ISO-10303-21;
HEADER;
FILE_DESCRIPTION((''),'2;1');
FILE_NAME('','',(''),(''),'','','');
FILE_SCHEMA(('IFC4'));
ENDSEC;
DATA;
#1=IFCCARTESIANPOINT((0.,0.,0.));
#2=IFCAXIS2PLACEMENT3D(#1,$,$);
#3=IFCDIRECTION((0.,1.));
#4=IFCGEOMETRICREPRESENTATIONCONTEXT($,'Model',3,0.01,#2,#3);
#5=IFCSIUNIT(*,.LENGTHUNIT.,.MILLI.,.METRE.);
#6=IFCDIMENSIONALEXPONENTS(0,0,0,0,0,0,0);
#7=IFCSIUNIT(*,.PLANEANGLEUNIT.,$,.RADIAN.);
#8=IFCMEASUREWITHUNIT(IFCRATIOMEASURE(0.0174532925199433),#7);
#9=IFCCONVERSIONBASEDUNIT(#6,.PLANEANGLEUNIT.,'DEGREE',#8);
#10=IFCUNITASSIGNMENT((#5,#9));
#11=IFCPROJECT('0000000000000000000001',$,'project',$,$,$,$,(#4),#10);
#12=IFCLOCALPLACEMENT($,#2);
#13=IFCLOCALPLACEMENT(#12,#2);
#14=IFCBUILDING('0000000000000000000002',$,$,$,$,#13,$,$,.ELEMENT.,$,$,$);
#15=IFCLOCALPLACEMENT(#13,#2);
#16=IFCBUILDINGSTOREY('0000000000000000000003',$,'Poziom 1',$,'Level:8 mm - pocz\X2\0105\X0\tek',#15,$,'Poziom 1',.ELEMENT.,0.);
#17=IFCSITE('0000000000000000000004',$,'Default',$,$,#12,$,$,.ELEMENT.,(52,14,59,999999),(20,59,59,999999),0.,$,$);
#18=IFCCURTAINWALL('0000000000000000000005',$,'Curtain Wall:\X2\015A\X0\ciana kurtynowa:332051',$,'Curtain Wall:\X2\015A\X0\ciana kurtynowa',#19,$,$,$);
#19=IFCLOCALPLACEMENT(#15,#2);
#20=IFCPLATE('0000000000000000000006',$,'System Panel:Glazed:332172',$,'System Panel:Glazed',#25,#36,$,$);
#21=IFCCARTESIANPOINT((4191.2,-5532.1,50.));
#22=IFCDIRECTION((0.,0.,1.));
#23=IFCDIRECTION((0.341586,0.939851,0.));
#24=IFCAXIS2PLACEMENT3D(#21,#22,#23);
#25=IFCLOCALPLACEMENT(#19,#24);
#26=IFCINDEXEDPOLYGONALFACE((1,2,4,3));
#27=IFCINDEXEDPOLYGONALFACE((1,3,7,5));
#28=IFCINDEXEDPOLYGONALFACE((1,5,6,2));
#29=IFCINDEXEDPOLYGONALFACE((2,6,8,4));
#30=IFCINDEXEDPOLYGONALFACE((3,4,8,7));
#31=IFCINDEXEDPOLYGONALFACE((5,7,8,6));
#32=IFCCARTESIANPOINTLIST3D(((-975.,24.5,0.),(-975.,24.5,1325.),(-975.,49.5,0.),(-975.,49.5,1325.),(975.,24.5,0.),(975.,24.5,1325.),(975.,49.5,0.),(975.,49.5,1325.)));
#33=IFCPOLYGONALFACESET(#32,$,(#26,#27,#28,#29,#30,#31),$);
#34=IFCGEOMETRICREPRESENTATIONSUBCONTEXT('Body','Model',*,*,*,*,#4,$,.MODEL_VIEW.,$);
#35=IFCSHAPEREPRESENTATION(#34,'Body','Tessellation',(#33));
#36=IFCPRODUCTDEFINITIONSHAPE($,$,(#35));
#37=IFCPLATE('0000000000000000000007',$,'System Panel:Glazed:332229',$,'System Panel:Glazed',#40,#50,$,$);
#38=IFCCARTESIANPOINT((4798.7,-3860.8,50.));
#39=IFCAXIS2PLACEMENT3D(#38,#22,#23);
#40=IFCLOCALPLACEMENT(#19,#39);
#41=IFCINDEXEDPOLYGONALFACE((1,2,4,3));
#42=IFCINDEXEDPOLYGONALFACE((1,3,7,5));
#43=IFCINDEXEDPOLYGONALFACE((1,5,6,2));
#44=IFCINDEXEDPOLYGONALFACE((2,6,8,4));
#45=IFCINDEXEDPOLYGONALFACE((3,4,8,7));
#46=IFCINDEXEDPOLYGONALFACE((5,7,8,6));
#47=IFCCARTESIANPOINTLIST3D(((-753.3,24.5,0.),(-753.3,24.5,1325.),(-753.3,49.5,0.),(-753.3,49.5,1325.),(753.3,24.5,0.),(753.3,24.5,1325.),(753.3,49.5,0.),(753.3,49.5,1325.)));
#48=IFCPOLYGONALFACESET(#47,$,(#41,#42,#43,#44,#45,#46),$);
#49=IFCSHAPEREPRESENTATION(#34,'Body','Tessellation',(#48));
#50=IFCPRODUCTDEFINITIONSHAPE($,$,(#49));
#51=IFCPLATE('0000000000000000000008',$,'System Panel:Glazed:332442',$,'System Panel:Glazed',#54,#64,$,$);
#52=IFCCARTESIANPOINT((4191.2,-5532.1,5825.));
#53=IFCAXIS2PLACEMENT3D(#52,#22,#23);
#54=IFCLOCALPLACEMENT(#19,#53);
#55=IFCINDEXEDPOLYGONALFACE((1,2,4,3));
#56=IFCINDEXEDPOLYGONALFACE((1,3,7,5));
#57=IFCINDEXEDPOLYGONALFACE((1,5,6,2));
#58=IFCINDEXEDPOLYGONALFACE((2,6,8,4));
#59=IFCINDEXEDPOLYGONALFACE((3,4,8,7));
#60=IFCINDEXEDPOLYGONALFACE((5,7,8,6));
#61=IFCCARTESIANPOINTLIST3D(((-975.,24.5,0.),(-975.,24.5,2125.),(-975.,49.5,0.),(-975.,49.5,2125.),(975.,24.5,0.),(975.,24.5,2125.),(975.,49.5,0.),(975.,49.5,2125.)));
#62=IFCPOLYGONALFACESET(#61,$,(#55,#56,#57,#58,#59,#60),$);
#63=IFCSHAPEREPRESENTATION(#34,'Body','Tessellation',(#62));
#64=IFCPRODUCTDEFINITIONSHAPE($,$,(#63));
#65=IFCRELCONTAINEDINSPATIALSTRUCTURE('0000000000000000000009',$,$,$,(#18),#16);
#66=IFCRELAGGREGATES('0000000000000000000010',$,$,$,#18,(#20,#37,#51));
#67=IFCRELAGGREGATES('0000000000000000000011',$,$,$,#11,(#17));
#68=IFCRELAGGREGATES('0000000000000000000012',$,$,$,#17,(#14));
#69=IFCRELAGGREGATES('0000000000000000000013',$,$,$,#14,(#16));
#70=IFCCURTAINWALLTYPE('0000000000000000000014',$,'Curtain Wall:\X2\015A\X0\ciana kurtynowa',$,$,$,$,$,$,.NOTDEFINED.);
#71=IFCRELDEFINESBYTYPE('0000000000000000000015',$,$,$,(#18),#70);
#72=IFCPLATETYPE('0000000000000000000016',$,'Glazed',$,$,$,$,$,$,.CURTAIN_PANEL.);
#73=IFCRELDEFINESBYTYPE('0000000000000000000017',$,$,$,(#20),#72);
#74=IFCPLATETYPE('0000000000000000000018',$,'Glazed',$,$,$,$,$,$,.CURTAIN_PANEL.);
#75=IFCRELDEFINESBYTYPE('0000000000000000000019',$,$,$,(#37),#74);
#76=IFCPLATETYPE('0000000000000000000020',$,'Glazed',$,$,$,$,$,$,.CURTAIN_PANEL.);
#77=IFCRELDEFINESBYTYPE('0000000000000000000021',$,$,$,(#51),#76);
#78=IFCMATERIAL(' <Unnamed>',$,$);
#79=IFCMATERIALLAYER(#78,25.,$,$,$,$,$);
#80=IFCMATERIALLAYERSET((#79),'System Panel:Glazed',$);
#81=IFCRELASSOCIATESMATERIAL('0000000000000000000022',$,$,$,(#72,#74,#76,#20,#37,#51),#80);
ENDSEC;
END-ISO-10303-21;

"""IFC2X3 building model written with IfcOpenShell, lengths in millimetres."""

from ifc_helpers import new_model, entity, si_unit, converted_unit, direction, frame, frame_2d, origin, origin_2d_with_axis, place, context, subcontext, project, spatial, rectangle, extrude, source, transform, mapped, material, layer, layer_set, layer_usage, type_object, type_shapes, element, aggregate, save


model = new_model("IFC2X3")

# Units and contexts
model_context = context("Model", 3, precision=0.01, world=origin(), true_north=direction((0.0, 1.0)))
body_context = subcontext(model_context, "Body", "Model", "MODEL_VIEW")
ifc_project = project(units=[si_unit("LENGTHUNIT", "METRE", prefix="MILLI"), converted_unit("PLANEANGLEUNIT", "DEGREE", entity("IfcRatioMeasure", 0.0174532925199433), si_unit("PLANEANGLEUNIT", "RADIAN"), dimensions=[0, 0, 0, 0, 0, 0, 0])], contexts=[model_context])

# Site, building, storey
site_placement = place(None, origin())
site = spatial("IfcSite", under=ifc_project, at=site_placement, Name="Default", CompositionType="ELEMENT", RefLatitude=(52, 14, 59, 999999), RefLongitude=(20, 59, 59, 999999), RefElevation=0.0)
building_placement = place(site_placement, origin())
building = spatial("IfcBuilding", under=site, at=building_placement, CompositionType="ELEMENT")
storey_placement = place(building_placement, origin())
storey = spatial("IfcBuildingStorey", under=building, at=storey_placement, Name="Poziom 1", ObjectType="Level:8 mm - początek", LongName="Poziom 1", CompositionType="ELEMENT", Elevation=0.0)

# Curtain wall, plates
curtain_wall_type = type_object("IfcCurtainWallType", Name="Curtain Wall:Ściana kurtynowa", PredefinedType="NOTDEFINED")
curtain_wall_placement = place(storey_placement, origin())
curtain_wall = element("IfcCurtainWall", 1, at=curtain_wall_placement, inside=storey, type_object=curtain_wall_type, Name="Curtain Wall:Ściana kurtynowa:332051", ObjectType="Curtain Wall:Ściana kurtynowa")
ifc_material_1 = material(Name=" <Unnamed>")
ifc_layer_1 = layer(ifc_material_1, 25.0)
ifc_layer_set_1 = layer_set([ifc_layer_1], Name="System Panel:Glazed")
ifc_layer_usage_1 = layer_usage(ifc_layer_set_1, "AXIS3", "POSITIVE", 0.1)
plate_type_1 = type_object("IfcPlateType", Name="Glazed", PredefinedType="CURTAIN_PANEL", material=ifc_layer_set_1)
shared_shape_1 = source(origin(), body_context, "Body", "SweptSolid", [
    extrude(rectangle(XDim=25.0, YDim=1950.0, at=origin_2d_with_axis()), frame((0.0, 37.0, 0.0), z_axis=(0.0, 0.0, 1.0), x_axis=(0.0, 1.0, 0.0)), (0.0, 0.0, 1.0), 1325.0),
])
type_shapes(plate_type_1, [shared_shape_1])
plate_1_placement = place(curtain_wall_placement, frame((4191.2, -5532.1, 50.0), z_axis=(0.0, 0.0, 1.0), x_axis=(0.341586, 0.939851, 0.0)))
plate_1 = element("IfcPlate", 2, at=plate_1_placement, type_object=plate_type_1, material=ifc_layer_usage_1, Name="System Panel:Glazed:332172", ObjectType="System Panel:Glazed", context=body_context, shape_type="MappedRepresentation", body=[
    mapped(shared_shape_1, transform((0.0, 0.0, 0.0), scale=1.0)),
])
ifc_layer_usage_2 = layer_usage(ifc_layer_set_1, "AXIS3", "POSITIVE", 0.1)
plate_type_2 = type_object("IfcPlateType", Name="Glazed", PredefinedType="CURTAIN_PANEL", material=ifc_layer_set_1)
shared_shape_2 = source(origin(), body_context, "Body", "SweptSolid", [
    extrude(rectangle(XDim=25.0, YDim=1506.6, at=origin_2d_with_axis()), frame((0.0, 37.0, 0.0), z_axis=(0.0, 0.0, 1.0), x_axis=(0.0, 1.0, 0.0)), (0.0, 0.0, 1.0), 1325.0),
])
type_shapes(plate_type_2, [shared_shape_2])
plate_2_placement = place(curtain_wall_placement, frame((4798.7, -3860.8, 50.0), z_axis=(0.0, 0.0, 1.0), x_axis=(0.341586, 0.939851, 0.0)))
plate_2 = element("IfcPlate", 3, at=plate_2_placement, type_object=plate_type_2, material=ifc_layer_usage_2, Name="System Panel:Glazed:332229", ObjectType="System Panel:Glazed", context=body_context, shape_type="MappedRepresentation", body=[
    mapped(shared_shape_2, transform((0.0, 0.0, 0.0), scale=1.0)),
])
ifc_layer_usage_3 = layer_usage(ifc_layer_set_1, "AXIS3", "POSITIVE", 0.1)
plate_type_3 = type_object("IfcPlateType", Name="Glazed", PredefinedType="CURTAIN_PANEL", material=ifc_layer_set_1)
shared_shape_3 = source(origin(), body_context, "Body", "SweptSolid", [
    extrude(rectangle(XDim=25.0, YDim=1950.0, at=frame_2d((0.0, 0.0), x_axis=(1.0, 0.0))), frame((0.0, 37.0, 0.0), z_axis=(0.0, 0.0, 1.0), x_axis=(0.0, 1.0, 0.0)), (0.0, 0.0, 1.0), 2125.0),
])
type_shapes(plate_type_3, [shared_shape_3])
plate_3_placement = place(curtain_wall_placement, frame((4191.2, -5532.1, 5825.0), z_axis=(0.0, 0.0, 1.0), x_axis=(0.341586, 0.939851, 0.0)))
plate_3 = element("IfcPlate", 4, at=plate_3_placement, type_object=plate_type_3, material=ifc_layer_usage_3, Name="System Panel:Glazed:332442", ObjectType="System Panel:Glazed", context=body_context, shape_type="MappedRepresentation", body=[
    mapped(shared_shape_3, transform((0.0, 0.0, 0.0), scale=1.0)),
])
aggregate(curtain_wall, [plate_1, plate_2, plate_3])

save(model, "model.ifc")
